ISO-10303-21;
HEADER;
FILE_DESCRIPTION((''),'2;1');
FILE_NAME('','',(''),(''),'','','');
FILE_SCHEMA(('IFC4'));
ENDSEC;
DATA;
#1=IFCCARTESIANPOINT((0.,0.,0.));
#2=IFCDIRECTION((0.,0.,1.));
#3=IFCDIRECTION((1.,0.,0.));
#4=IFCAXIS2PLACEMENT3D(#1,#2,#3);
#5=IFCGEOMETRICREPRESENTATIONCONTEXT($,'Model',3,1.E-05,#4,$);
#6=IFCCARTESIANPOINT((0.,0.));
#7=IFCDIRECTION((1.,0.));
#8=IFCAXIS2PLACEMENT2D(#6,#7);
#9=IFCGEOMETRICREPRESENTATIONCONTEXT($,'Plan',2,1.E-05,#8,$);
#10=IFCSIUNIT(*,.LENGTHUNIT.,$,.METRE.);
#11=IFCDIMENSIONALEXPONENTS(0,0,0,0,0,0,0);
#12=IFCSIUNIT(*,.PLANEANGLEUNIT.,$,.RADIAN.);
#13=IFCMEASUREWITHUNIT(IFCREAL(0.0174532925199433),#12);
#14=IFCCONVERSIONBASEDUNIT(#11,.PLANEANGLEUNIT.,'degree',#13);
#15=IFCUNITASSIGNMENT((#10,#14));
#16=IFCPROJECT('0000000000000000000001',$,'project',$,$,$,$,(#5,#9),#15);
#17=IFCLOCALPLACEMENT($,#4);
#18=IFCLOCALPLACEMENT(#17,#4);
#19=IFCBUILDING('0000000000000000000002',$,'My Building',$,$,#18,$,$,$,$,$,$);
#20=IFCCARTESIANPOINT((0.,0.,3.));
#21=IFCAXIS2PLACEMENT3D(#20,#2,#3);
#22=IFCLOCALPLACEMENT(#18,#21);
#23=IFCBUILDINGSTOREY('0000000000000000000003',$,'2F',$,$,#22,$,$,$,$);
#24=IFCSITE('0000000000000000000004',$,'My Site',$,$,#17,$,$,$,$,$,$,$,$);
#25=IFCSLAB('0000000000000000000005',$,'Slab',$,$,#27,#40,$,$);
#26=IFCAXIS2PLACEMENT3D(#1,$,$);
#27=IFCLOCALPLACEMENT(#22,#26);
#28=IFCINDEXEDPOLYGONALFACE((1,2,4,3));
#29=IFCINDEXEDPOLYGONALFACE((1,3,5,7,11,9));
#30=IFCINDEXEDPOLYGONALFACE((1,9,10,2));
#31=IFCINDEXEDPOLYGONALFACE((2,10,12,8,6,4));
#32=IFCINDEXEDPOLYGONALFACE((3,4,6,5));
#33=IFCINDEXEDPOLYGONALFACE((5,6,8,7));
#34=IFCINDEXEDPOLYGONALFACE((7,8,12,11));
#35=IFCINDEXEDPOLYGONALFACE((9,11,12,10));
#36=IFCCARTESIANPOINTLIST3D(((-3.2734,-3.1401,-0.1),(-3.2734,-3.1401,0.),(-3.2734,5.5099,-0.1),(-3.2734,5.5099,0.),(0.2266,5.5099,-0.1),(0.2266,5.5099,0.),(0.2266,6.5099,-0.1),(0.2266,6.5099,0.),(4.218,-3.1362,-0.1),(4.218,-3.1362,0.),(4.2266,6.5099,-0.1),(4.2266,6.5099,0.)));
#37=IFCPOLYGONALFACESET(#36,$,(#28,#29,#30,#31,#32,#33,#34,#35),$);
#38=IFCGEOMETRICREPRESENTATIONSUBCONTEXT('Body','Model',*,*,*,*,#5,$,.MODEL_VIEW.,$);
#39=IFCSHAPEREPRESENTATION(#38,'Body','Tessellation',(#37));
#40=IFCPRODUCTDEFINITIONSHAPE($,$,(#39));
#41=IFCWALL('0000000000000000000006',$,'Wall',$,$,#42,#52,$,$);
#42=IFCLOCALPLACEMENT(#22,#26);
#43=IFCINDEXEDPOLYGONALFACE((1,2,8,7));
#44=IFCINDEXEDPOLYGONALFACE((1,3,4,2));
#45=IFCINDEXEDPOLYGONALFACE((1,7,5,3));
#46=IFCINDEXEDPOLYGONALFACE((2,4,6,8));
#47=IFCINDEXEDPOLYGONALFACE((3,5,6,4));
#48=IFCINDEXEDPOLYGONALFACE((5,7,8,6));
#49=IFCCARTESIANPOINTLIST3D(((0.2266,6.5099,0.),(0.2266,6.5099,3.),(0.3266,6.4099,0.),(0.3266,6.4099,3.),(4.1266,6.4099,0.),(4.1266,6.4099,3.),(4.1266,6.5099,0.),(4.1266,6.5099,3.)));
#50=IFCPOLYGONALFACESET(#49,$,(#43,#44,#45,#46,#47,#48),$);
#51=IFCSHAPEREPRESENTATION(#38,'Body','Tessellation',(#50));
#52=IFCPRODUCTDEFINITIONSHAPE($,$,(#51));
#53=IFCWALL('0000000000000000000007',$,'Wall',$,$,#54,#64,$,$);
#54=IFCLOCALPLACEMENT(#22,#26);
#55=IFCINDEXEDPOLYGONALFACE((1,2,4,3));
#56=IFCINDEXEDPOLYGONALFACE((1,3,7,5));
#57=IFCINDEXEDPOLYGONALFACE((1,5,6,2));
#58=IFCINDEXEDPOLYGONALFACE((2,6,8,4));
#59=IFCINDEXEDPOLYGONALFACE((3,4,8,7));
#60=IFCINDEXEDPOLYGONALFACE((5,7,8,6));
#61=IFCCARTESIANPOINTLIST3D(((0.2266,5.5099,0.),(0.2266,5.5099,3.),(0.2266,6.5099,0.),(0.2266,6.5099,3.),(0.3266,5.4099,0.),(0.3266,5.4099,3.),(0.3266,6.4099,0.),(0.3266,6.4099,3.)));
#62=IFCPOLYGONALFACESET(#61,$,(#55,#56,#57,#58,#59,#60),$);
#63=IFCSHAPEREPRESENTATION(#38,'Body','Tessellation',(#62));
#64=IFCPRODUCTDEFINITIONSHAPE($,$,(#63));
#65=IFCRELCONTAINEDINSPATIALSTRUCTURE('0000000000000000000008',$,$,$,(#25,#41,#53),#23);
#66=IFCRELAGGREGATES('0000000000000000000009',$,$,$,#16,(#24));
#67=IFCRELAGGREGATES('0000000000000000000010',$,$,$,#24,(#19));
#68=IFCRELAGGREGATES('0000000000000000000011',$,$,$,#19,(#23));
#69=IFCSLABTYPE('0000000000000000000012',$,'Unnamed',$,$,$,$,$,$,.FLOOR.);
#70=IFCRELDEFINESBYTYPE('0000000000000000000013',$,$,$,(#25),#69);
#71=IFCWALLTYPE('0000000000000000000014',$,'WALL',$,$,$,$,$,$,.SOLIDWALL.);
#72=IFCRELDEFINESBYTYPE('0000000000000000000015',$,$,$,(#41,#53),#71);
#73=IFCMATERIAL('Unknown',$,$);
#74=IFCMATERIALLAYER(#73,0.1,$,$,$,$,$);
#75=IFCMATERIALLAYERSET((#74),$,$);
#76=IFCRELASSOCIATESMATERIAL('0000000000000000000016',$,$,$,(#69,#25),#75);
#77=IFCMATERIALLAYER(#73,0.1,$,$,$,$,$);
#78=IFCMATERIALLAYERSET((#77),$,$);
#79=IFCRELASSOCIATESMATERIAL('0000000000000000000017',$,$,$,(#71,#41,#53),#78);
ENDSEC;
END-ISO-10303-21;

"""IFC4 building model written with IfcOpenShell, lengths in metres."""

from ifc_helpers import new_model, entity, si_unit, converted_unit, frame, origin_with_axes, origin_2d_with_axis, place, context, subcontext, project, spatial, line, indexed_curve, outline, extrude, material, layer, layer_set, layer_usage, type_object, element, save


model = new_model("IFC4")

# Units and contexts
model_context = context("Model", 3, precision=1e-05, world=origin_with_axes())
plan_context = context("Plan", 2, precision=1e-05, world=origin_2d_with_axis())
body_context_1 = subcontext(model_context, "Body", "Model", "MODEL_VIEW")
ifc_project = project(units=[si_unit("LENGTHUNIT", "METRE"), converted_unit("PLANEANGLEUNIT", "degree", entity("IfcReal", 0.0174532925199433), si_unit("PLANEANGLEUNIT", "RADIAN"), dimensions=[0, 0, 0, 0, 0, 0, 0])], contexts=[model_context, plan_context])

# Site, building, storey
site_placement = place(None, origin_with_axes())
site = spatial("IfcSite", under=ifc_project, at=site_placement, Name="My Site")
building_placement = place(site_placement, origin_with_axes())
building = spatial("IfcBuilding", under=site, at=building_placement, Name="My Building")
storey_placement = place(building_placement, frame((0.0, 0.0, 3.0), z_axis=(0.0, 0.0, 1.0), x_axis=(1.0, 0.0, 0.0)))
storey = spatial("IfcBuildingStorey", under=building, at=storey_placement, Name="2F")

# Slab
ifc_material = material(Name="Unknown")
ifc_layer_1 = layer(ifc_material, 0.1)
ifc_layer_set_1 = layer_set([ifc_layer_1])
ifc_layer_usage_1 = layer_usage(ifc_layer_set_1, "AXIS3", "POSITIVE", -0.1)
slab_type = type_object("IfcSlabType", Name="Unnamed", PredefinedType="FLOOR", material=ifc_layer_set_1)
slab_placement = place(storey_placement, frame((4.2266, 6.5099, 0.0), z_axis=(0.0, 0.0, 1.0), x_axis=(1.0, 0.0, 0.0)))
element("IfcSlab", 1, at=slab_placement, inside=storey, type_object=slab_type, material=ifc_layer_usage_1, Name="Slab", context=body_context_1, shape_type="SweptSolid", body=[
    extrude(outline(indexed_curve([(0.0, 0.0), (-4.0, 0.0), (-4.0, -1.0), (-7.5, -1.0), (-7.5, -9.65), (-0.0086, -9.6461), (0.0, 0.0)])), frame((0.0, 0.0, -0.1), z_axis=(0.0, 0.0, 1.0), x_axis=(1.0, 0.0, 0.0)), (0.0, 0.0, 1.0), 0.1),
])

# Walls
ifc_layer_2 = layer(ifc_material, 0.1)
ifc_layer_set_2 = layer_set([ifc_layer_2])
ifc_layer_usage_2 = layer_usage(ifc_layer_set_2, "AXIS2", "POSITIVE", 0.0)
wall_type = type_object("IfcWallType", Name="WALL", PredefinedType="SOLIDWALL", material=ifc_layer_set_2)
wall_1_placement = place(storey_placement, frame((4.1266, 6.5099, 0.0), z_axis=(0.0, 0.0, 1.0), x_axis=(-1.0, 0.0, 0.0)))
element("IfcWall", 2, at=wall_1_placement, inside=storey, type_object=wall_type, material=ifc_layer_usage_2, Name="Wall", context=body_context_1, shape_type="SweptSolid", body=[
    extrude(outline(indexed_curve([(0.0, 0.0), (0.0, 0.1), (3.8, 0.1), (3.9, 0.0)], segments=[line(1, 2, 3, 4, 1)])), origin_with_axes(), (0.0, 0.0, 1.0), 3.0),
])
ifc_layer_usage_3 = layer_usage(ifc_layer_set_2, "AXIS2", "POSITIVE", 0.0)
wall_2_placement = place(storey_placement, frame((0.2266, 6.5099, 0.0), z_axis=(0.0, 0.0, 1.0), x_axis=(0.0, -1.0, 0.0)))
element("IfcWall", 3, at=wall_2_placement, inside=storey, type_object=wall_type, material=ifc_layer_usage_3, Name="Wall", context=body_context_1, shape_type="SweptSolid", body=[
    extrude(outline(indexed_curve([(0.0, 0.0), (0.1, 0.1), (1.1, 0.1), (1.0, 0.0)], segments=[line(1, 2, 3, 4, 1)])), origin_with_axes(), (0.0, 0.0, 1.0), 3.0),
])

save(model, "model.ifc")
